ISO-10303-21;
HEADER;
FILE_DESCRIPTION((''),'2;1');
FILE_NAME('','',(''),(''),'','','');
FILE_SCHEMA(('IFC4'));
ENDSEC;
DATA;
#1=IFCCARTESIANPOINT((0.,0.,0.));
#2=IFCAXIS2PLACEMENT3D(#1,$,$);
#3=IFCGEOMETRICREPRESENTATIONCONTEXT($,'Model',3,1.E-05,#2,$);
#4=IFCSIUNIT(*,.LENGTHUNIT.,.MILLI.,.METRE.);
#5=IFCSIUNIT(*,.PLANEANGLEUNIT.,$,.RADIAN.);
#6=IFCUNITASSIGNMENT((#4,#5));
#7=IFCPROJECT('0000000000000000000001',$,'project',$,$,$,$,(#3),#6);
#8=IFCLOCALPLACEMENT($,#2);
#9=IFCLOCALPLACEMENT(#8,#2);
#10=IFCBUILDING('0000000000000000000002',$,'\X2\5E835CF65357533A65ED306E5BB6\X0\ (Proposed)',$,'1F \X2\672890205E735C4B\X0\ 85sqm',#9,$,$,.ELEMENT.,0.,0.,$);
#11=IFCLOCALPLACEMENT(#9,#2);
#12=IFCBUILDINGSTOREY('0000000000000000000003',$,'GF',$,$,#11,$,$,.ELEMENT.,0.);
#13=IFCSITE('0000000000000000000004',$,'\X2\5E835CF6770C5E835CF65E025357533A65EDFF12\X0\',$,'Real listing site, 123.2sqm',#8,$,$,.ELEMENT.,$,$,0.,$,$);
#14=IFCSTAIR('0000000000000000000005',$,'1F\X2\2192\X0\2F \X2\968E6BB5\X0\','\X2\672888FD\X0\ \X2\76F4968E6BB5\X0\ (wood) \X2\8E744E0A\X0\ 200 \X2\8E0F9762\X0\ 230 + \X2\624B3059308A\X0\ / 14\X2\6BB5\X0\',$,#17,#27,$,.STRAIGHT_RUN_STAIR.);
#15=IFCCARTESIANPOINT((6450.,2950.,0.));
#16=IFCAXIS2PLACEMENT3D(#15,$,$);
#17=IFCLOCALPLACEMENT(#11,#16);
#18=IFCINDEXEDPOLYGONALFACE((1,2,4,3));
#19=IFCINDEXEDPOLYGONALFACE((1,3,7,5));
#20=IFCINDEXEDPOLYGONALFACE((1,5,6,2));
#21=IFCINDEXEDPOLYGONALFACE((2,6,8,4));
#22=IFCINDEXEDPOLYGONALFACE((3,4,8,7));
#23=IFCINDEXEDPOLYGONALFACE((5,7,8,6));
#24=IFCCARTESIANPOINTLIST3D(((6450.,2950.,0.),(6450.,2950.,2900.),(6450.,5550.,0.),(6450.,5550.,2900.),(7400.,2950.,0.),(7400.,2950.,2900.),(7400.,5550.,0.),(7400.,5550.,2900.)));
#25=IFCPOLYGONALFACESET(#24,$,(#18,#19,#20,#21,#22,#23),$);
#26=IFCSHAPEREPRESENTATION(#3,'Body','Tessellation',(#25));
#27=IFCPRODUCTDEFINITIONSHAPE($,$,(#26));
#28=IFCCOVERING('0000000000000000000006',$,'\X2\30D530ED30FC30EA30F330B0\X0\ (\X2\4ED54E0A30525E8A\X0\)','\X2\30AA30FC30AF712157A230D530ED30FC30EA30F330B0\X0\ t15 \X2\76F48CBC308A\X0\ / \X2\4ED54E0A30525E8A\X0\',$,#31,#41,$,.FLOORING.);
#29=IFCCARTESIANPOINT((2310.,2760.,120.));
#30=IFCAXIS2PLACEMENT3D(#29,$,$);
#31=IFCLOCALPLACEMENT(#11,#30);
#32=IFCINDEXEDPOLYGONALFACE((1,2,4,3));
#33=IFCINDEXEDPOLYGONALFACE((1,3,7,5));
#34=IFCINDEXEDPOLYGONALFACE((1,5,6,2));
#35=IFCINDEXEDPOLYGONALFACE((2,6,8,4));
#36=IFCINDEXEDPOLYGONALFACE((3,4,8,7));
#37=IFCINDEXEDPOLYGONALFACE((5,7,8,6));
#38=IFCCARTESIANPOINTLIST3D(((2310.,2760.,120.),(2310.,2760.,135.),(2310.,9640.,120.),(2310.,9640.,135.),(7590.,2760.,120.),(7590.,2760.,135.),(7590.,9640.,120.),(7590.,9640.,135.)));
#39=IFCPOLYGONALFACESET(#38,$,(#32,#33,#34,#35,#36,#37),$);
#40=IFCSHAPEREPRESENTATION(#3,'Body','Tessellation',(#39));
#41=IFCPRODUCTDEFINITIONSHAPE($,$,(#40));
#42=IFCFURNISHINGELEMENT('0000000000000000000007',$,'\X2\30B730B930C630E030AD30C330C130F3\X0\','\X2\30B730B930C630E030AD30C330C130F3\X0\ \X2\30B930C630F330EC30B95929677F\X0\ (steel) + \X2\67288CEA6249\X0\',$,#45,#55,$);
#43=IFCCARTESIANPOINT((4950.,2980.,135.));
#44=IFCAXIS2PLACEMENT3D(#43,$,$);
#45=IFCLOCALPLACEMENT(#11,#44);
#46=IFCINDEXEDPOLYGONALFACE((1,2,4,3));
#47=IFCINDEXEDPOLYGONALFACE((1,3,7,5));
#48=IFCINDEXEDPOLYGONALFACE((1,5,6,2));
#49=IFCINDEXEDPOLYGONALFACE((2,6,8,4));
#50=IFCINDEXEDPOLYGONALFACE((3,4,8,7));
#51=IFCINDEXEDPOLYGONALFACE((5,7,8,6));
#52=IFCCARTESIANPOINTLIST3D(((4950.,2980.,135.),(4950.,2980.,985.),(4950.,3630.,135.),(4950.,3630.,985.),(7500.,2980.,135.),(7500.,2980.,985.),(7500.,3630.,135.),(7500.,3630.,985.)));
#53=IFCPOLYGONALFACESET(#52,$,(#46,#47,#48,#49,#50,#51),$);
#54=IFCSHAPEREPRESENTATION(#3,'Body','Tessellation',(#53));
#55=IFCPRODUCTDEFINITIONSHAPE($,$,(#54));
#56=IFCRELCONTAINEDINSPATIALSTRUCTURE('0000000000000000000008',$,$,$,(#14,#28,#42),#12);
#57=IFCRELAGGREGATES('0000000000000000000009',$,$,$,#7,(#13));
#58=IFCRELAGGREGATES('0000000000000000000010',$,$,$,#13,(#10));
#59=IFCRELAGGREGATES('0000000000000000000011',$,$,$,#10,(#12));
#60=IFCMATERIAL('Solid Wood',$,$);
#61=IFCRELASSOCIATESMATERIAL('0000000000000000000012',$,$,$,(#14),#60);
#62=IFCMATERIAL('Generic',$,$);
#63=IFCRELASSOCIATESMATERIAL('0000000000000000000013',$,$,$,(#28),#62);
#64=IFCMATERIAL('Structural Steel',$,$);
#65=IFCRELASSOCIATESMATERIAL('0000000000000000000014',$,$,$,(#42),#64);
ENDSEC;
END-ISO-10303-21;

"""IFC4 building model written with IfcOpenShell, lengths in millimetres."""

from ifc_helpers import new_model, si_unit, frame, frame_2d, origin, place, context, project, spatial, rectangle, extrude, material, element, save


model = new_model("IFC4")

# Units and contexts
model_context = context("Model", 3, precision=1e-05, world=origin())
ifc_project = project(units=[si_unit("LENGTHUNIT", "METRE", prefix="MILLI"), si_unit("PLANEANGLEUNIT", "RADIAN")], contexts=[model_context])

# Site, building, storey
site_placement = place(None, origin())
site = spatial("IfcSite", under=ifc_project, at=site_placement, Name="広島県広島市南区旭２", ObjectType="Real listing site, 123.2sqm", CompositionType="ELEMENT", RefElevation=0.0)
building_placement = place(site_placement, origin())
building = spatial("IfcBuilding", under=site, at=building_placement, Name="広島南区旭の家 (Proposed)", ObjectType="1F 木造平屋 85sqm", CompositionType="ELEMENT", ElevationOfRefHeight=0.0, ElevationOfTerrain=0.0)
storey_placement = place(building_placement, origin())
storey = spatial("IfcBuildingStorey", under=building, at=storey_placement, Name="GF", CompositionType="ELEMENT", Elevation=0.0)

# Shared definitions
ifc_material_1 = material(Name="Solid Wood")
ifc_material_2 = material(Name="Generic")

# Stair
stair_placement = place(storey_placement, frame((6450.0, 2950.0, 0.0)))
element("IfcStair", 1, at=stair_placement, inside=storey, material=ifc_material_1, Name="1F→2F 階段", Description="木製 直階段 (wood) 蹴上 200 踏面 230 + 手すり / 14段", PredefinedType="STRAIGHT_RUN_STAIR", context=model_context, shape_type="SweptSolid", body=[
    extrude(rectangle(XDim=950.0, YDim=2600.0, at=frame_2d((475.0, 1300.0))), frame((6450.0, 2950.0, 0.0)), (0.0, 0.0, 1.0), 2900.0),
])

# Covering
covering_placement = place(storey_placement, frame((2310.0, 2760.0, 120.0)))
element("IfcCovering", 2, at=covering_placement, inside=storey, material=ifc_material_2, Name="フローリング (仕上げ床)", Description="オーク無垢フローリング t15 直貼り / 仕上げ床", PredefinedType="FLOORING", context=model_context, shape_type="SweptSolid", body=[
    extrude(rectangle(XDim=5280.0, YDim=6880.0, at=frame_2d((2640.0, 3440.0))), frame((2310.0, 2760.0, 120.0)), (0.0, 0.0, 1.0), 15.0),
])

# Furnishing element
ifc_material_3 = material(Name="Structural Steel")
furnishing_placement = place(storey_placement, frame((4950.0, 2980.0, 135.0)))
element("IfcFurnishingElement", 3, at=furnishing_placement, inside=storey, material=ifc_material_3, Name="システムキッチン", Description="システムキッチン ステンレス天板 (steel) + 木質扉", context=model_context, shape_type="SweptSolid", body=[
    extrude(rectangle(XDim=2550.0, YDim=650.0, at=frame_2d((1275.0, 325.0))), frame((4950.0, 2980.0, 135.0)), (0.0, 0.0, 1.0), 850.0),
])

save(model, "model.ifc")
